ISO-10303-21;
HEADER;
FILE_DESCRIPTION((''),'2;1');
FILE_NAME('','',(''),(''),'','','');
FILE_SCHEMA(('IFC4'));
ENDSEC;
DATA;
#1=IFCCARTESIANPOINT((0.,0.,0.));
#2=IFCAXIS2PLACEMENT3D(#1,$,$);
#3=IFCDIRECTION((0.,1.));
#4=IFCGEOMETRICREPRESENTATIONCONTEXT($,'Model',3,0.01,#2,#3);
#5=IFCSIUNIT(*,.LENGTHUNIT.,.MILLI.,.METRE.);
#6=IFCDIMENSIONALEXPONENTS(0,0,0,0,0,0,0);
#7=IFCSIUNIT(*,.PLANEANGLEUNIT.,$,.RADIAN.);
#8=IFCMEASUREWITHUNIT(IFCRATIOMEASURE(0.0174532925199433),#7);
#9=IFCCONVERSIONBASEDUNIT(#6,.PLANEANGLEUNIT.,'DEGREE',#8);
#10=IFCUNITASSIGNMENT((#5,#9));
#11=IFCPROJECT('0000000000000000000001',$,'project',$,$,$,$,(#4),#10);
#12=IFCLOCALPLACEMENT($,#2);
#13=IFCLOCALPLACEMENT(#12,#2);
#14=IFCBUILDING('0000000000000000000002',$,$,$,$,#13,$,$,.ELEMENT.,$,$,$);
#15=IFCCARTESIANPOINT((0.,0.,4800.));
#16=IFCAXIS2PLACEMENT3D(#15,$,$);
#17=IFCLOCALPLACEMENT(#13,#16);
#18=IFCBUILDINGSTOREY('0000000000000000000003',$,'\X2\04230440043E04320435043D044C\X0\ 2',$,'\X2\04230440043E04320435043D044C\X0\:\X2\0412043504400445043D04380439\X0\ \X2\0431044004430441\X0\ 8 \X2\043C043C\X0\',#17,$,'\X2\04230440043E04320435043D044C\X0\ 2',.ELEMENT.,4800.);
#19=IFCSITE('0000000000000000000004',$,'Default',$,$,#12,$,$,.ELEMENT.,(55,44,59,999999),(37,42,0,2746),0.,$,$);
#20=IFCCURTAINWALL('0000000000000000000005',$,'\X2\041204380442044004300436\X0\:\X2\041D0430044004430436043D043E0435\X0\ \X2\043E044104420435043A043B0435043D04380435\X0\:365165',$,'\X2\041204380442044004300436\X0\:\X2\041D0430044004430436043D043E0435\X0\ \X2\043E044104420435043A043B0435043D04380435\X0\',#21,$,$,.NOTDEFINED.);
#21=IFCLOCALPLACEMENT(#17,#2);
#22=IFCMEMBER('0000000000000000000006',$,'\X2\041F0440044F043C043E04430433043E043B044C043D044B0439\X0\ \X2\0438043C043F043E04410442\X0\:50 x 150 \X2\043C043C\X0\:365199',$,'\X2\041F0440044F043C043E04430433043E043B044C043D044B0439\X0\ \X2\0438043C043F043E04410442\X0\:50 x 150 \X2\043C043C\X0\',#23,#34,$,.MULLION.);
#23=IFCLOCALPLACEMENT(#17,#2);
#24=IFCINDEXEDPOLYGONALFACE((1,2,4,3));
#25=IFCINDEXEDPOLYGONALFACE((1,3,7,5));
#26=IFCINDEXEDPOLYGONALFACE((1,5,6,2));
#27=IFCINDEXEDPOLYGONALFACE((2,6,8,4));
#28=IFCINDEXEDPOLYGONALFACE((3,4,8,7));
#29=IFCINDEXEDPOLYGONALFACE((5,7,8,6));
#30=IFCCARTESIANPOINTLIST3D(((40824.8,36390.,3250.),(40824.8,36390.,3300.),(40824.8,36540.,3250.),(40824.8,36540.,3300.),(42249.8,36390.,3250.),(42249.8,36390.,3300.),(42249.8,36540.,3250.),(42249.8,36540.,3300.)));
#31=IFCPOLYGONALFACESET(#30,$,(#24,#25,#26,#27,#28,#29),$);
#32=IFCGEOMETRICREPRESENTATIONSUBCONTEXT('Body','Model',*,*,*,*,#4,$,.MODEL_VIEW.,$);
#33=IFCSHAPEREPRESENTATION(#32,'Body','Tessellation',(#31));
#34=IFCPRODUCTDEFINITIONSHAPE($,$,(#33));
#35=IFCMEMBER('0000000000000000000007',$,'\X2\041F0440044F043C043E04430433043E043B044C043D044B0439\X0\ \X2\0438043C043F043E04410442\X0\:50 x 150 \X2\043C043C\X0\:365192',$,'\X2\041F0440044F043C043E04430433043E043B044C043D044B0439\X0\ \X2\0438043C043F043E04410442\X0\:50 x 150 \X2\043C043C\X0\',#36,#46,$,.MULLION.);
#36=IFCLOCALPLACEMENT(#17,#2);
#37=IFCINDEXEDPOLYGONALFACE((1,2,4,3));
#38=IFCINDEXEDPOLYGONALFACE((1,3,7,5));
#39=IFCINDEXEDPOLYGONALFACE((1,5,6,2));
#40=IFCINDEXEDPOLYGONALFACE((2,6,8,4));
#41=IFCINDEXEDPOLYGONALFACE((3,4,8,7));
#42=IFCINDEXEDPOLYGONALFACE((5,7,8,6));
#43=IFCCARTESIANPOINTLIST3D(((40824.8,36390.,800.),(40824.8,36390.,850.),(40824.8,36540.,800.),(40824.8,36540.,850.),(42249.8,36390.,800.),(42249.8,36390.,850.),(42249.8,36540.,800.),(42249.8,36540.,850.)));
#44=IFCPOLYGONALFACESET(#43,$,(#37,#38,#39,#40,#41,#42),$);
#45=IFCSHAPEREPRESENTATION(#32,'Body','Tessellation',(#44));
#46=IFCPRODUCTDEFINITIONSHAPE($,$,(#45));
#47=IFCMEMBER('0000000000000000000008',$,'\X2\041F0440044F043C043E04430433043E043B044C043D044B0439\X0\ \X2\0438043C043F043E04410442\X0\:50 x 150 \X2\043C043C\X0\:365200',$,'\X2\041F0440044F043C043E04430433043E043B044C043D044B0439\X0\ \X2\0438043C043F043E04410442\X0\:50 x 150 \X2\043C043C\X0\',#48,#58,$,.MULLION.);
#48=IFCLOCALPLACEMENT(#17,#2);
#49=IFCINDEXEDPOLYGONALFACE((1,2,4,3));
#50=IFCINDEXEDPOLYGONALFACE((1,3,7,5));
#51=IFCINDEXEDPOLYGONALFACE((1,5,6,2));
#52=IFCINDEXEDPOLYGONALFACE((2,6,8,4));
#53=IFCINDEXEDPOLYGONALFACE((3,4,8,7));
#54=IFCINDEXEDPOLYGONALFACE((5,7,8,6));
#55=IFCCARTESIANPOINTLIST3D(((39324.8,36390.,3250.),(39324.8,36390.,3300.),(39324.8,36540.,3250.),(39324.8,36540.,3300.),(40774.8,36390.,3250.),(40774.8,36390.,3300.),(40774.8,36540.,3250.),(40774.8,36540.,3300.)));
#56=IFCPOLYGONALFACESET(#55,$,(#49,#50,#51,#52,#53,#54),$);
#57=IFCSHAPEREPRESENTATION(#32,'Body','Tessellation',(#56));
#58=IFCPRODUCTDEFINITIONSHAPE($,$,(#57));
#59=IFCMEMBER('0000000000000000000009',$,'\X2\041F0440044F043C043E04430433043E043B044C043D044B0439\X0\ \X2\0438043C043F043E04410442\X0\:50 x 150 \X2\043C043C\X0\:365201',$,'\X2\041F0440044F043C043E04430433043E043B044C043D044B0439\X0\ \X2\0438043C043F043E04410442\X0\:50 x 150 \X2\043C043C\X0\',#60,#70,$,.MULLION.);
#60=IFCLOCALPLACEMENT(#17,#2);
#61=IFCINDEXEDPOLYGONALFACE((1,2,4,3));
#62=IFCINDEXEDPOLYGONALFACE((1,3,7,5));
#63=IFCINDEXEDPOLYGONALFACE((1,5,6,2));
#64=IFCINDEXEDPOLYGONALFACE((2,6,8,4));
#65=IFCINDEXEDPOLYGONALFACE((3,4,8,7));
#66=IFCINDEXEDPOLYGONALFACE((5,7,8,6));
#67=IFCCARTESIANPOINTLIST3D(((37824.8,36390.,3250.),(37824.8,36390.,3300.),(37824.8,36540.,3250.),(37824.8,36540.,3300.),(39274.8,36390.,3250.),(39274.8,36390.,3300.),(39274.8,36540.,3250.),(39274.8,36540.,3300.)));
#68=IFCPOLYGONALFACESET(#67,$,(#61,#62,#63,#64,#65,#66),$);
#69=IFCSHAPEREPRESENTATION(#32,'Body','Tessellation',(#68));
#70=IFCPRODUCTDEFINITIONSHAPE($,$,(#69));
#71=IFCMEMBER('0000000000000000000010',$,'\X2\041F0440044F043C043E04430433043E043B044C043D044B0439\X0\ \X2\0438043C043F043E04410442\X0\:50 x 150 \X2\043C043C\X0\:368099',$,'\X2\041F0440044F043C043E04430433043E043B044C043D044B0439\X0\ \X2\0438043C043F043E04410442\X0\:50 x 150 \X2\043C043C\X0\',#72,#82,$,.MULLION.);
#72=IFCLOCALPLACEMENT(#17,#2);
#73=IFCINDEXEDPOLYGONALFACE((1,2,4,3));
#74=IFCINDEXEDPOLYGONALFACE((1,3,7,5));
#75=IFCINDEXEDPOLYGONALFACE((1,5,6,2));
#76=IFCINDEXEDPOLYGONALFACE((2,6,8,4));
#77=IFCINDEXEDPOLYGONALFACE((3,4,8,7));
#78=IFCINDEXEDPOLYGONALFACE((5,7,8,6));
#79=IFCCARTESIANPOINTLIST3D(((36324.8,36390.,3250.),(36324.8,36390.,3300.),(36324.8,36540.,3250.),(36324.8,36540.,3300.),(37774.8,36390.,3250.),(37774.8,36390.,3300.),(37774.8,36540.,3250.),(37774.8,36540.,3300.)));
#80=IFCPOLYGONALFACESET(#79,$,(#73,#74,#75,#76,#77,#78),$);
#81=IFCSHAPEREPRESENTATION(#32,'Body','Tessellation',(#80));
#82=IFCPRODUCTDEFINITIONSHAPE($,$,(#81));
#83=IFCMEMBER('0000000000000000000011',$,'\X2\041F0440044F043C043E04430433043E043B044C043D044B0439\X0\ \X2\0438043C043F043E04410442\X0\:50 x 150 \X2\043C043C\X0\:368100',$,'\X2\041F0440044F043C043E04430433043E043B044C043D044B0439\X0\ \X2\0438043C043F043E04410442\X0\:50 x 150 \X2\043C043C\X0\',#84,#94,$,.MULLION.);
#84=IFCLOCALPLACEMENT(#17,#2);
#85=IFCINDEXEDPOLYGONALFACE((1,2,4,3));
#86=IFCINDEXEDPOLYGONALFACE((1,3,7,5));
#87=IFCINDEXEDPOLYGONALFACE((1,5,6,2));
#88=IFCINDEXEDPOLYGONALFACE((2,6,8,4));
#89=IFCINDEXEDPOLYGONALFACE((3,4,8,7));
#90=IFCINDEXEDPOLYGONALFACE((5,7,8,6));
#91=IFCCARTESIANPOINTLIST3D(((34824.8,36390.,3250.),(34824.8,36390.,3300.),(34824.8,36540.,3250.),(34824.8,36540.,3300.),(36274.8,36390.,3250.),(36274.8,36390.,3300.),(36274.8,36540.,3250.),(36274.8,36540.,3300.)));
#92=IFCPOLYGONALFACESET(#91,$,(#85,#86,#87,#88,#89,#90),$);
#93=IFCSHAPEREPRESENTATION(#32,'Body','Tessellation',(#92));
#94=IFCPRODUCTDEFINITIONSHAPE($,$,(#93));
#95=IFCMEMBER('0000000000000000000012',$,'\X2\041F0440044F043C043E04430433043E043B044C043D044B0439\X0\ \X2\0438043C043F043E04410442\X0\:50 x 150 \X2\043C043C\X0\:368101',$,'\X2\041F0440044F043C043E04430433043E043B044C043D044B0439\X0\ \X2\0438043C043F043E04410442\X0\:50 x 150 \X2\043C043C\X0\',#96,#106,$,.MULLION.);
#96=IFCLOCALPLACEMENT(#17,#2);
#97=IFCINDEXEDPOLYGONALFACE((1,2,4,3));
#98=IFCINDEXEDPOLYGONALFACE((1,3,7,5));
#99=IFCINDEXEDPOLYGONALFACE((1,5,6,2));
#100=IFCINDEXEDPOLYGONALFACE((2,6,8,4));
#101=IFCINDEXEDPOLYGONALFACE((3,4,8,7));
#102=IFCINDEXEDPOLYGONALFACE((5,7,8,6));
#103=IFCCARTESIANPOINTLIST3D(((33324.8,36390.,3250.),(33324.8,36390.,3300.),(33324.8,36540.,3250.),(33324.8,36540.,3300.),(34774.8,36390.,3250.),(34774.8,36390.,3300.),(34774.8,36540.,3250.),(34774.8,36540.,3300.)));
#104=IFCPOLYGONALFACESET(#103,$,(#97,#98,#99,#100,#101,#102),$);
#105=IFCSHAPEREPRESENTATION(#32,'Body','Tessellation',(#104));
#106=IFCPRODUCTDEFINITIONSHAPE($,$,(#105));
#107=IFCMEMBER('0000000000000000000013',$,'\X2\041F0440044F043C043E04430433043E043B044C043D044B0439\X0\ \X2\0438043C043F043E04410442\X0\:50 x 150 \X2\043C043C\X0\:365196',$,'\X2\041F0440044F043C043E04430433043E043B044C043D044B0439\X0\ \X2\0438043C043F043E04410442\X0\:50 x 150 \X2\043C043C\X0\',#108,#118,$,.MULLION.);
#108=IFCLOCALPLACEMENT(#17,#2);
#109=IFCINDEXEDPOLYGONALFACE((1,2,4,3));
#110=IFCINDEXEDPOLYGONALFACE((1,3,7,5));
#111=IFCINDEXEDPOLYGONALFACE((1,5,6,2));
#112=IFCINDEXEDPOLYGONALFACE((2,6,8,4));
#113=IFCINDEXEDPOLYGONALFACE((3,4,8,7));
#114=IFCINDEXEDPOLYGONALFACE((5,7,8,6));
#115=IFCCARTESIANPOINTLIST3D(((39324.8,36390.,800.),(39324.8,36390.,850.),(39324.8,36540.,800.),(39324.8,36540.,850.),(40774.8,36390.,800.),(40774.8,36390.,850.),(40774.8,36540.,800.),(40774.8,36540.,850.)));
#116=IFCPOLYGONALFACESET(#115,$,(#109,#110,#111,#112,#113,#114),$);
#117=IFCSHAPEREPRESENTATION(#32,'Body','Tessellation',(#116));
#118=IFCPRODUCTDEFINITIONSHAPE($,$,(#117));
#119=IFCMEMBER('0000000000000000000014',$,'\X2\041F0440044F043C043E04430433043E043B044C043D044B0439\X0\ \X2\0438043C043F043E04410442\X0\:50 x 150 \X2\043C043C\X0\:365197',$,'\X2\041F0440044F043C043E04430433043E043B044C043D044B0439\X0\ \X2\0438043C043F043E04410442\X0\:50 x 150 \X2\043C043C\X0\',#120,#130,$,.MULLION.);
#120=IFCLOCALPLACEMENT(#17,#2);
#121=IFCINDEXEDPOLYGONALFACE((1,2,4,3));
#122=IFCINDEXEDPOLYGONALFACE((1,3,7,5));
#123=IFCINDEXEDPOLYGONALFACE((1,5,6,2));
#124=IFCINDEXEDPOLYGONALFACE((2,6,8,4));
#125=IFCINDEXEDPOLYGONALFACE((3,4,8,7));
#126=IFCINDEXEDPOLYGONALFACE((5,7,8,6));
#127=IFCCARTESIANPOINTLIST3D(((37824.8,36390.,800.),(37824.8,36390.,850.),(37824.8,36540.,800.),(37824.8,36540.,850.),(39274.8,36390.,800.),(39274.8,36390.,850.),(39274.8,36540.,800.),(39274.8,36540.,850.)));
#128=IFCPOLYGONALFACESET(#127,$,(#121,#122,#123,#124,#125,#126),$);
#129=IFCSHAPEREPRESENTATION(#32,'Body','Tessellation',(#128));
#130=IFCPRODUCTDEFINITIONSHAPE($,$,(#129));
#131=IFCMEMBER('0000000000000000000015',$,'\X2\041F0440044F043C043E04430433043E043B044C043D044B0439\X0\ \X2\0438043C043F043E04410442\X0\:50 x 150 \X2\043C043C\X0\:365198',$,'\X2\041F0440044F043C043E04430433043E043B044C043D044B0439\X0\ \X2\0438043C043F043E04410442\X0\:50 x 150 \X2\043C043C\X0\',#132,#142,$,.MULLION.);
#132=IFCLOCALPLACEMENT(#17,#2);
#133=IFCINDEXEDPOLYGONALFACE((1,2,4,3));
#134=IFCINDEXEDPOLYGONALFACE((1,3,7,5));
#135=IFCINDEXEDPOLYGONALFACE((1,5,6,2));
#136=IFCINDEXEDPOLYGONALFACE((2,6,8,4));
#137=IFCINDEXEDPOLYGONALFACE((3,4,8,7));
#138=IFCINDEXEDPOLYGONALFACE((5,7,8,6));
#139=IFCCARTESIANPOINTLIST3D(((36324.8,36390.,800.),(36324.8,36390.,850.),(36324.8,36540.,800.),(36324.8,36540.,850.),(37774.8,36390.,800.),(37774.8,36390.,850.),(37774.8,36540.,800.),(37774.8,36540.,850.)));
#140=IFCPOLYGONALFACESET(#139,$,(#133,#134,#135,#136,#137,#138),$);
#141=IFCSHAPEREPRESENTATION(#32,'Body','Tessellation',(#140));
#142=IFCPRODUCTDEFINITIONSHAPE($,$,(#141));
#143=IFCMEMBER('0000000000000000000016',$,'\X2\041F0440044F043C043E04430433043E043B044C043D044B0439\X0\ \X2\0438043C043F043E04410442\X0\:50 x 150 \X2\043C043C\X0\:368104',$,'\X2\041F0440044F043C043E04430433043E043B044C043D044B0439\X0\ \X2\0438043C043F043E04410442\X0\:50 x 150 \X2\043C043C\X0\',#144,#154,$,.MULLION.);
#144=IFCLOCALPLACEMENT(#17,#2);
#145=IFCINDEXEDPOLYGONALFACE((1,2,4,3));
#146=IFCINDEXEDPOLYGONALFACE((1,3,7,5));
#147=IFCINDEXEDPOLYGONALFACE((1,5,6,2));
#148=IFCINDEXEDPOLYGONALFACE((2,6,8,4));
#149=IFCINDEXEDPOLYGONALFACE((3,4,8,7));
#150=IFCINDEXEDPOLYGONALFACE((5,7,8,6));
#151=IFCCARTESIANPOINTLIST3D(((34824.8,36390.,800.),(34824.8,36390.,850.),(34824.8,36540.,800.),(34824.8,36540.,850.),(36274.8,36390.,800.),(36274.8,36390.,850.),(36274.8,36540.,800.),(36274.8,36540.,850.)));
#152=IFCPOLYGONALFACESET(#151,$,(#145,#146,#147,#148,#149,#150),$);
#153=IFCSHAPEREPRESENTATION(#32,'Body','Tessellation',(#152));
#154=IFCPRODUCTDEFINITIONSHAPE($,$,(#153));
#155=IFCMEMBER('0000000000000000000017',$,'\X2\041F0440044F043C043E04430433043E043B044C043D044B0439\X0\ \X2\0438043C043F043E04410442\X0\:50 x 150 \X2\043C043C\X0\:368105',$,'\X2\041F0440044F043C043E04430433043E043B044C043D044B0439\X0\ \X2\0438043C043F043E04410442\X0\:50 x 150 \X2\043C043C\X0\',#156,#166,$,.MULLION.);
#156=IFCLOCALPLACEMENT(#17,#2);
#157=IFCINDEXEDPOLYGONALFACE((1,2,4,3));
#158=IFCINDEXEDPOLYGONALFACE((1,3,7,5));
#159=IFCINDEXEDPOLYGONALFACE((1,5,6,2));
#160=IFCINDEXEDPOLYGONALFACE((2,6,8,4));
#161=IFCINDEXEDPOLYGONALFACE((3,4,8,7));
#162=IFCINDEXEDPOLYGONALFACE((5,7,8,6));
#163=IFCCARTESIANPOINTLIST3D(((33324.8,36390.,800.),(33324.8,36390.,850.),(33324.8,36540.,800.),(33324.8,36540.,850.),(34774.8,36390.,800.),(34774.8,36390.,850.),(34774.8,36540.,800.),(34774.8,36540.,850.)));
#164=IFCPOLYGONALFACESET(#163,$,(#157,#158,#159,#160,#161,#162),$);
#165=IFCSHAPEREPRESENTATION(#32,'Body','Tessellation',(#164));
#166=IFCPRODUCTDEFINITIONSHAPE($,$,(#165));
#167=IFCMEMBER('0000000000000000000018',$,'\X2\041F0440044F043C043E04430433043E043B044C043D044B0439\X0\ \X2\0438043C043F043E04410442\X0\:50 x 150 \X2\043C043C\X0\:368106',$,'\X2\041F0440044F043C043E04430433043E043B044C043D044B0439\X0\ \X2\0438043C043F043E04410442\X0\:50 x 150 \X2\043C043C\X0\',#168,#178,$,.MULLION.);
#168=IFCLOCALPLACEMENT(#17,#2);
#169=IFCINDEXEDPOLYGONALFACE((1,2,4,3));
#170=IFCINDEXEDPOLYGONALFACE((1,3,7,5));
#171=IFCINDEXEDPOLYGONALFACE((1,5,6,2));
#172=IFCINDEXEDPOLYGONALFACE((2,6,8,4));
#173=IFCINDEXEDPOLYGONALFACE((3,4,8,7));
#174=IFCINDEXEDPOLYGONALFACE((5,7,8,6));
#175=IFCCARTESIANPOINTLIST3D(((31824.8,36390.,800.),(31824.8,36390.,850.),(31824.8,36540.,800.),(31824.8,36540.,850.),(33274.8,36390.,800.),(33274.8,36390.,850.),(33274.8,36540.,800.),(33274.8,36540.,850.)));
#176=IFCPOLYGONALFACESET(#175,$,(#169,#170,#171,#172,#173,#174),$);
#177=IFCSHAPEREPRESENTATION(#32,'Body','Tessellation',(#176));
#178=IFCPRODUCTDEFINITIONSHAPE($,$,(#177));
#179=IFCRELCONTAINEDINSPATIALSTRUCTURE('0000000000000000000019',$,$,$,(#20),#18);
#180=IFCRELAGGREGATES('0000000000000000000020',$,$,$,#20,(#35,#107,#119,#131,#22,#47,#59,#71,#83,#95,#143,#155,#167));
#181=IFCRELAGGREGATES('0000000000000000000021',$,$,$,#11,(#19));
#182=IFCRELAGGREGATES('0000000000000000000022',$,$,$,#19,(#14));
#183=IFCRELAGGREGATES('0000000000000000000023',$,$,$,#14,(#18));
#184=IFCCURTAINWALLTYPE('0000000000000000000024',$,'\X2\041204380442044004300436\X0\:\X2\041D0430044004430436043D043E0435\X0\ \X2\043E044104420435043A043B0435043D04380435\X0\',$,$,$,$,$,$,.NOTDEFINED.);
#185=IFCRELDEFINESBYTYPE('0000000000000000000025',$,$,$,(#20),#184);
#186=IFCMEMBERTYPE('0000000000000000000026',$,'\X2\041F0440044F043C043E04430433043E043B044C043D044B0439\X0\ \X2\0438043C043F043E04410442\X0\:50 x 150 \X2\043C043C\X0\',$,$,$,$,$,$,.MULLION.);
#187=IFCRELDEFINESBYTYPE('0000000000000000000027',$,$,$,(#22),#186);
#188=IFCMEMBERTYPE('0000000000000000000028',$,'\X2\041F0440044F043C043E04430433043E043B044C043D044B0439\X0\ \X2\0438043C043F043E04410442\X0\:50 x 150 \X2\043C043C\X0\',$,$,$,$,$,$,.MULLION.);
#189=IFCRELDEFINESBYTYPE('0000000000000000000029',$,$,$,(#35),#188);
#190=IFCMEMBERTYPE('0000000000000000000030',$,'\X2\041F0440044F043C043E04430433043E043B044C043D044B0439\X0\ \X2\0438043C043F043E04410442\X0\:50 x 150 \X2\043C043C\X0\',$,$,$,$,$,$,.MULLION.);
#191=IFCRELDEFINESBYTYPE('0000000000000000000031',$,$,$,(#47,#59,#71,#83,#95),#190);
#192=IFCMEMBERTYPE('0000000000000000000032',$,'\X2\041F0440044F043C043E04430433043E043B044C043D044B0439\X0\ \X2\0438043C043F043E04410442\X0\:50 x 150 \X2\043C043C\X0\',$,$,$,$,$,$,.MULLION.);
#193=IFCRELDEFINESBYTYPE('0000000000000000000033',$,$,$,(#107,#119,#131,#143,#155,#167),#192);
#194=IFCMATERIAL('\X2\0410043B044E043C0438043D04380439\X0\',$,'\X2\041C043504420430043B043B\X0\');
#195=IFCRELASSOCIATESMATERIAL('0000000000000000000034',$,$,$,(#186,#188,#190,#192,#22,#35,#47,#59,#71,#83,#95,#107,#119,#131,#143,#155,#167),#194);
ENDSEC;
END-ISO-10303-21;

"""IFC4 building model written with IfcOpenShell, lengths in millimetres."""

from ifc_helpers import new_model, entity, si_unit, converted_unit, direction, frame, origin, origin_2d_with_axis, place, context, subcontext, project, spatial, rectangle, extrude, source, transform, mapped, material, material_profile, profile_set, profile_usage, type_object, type_shapes, element, aggregate, save


model = new_model("IFC4")

# Units and contexts
model_context = context("Model", 3, precision=0.01, world=origin(), true_north=direction((0.0, 1.0)))
body_context = subcontext(model_context, "Body", "Model", "MODEL_VIEW")
ifc_project = project(units=[si_unit("LENGTHUNIT", "METRE", prefix="MILLI"), converted_unit("PLANEANGLEUNIT", "DEGREE", entity("IfcRatioMeasure", 0.0174532925199433), si_unit("PLANEANGLEUNIT", "RADIAN"), dimensions=[0, 0, 0, 0, 0, 0, 0])], contexts=[model_context])

# Site, building, storey
site_placement = place(None, origin())
site = spatial("IfcSite", under=ifc_project, at=site_placement, Name="Default", CompositionType="ELEMENT", RefLatitude=(55, 44, 59, 999999), RefLongitude=(37, 42, 0, 2746), RefElevation=0.0)
building_placement = place(site_placement, origin())
building = spatial("IfcBuilding", under=site, at=building_placement, CompositionType="ELEMENT")
storey_placement = place(building_placement, frame((0.0, 0.0, 4800.0)))
storey = spatial("IfcBuildingStorey", under=building, at=storey_placement, Name="Уровень 2", ObjectType="Уровень:Верхний брус 8 мм", LongName="Уровень 2", CompositionType="ELEMENT", Elevation=4800.0)

# Curtain wall, members
curtain_wall_type = type_object("IfcCurtainWallType", Name="Витраж:Наружное остекление", PredefinedType="NOTDEFINED")
curtain_wall_placement = place(storey_placement, frame((0.0, 0.0, -4800.0)))
curtain_wall = element("IfcCurtainWall", 1, at=curtain_wall_placement, inside=storey, type_object=curtain_wall_type, Name="Витраж:Наружное остекление:365165", ObjectType="Витраж:Наружное остекление", PredefinedType="NOTDEFINED")
ifc_material_1 = material(Name="Алюминий", Category="Металл")
ifc_material_profile = material_profile(ifc_material_1, rectangle(XDim=150.0, YDim=50.0, at=origin_2d_with_axis()), Name="50 x 150 мм")
ifc_profile_set = profile_set([ifc_material_profile], Name="50 x 150 мм")
ifc_profile_usage_1 = profile_usage(ifc_profile_set)
member_type_1 = type_object("IfcMemberType", Name="Прямоугольный импост:50 x 150 мм", PredefinedType="MULLION", material=ifc_profile_set)
shared_shape_1 = source(origin(), body_context, "Body", "SweptSolid", [
    extrude(rectangle(XDim=150.0, YDim=50.0, at=origin_2d_with_axis()), frame((-25.0, 0.0, -1425.0), z_axis=(0.0, 0.0, 1.0), x_axis=(0.0, -1.0, 0.0)), (0.0, 0.0, 1.0), 1425.0),
])
type_shapes(member_type_1, [shared_shape_1])
member_1_placement = place(storey_placement, frame((40824.8, 36465.0, 3300.0), z_axis=(-1.0, 0.0, 0.0), x_axis=(0.0, 0.0, 1.0)))
member_1 = element("IfcMember", 2, at=member_1_placement, type_object=member_type_1, material=ifc_profile_usage_1, Name="Прямоугольный импост:50 x 150 мм:365199", ObjectType="Прямоугольный импост:50 x 150 мм", PredefinedType="MULLION", context=body_context, shape_type="MappedRepresentation", body=[
    mapped(shared_shape_1, transform((0.0, 0.0, 0.0), scale=1.0)),
])
ifc_profile_usage_2 = profile_usage(ifc_profile_set)
member_type_2 = type_object("IfcMemberType", Name="Прямоугольный импост:50 x 150 мм", PredefinedType="MULLION", material=ifc_profile_set)
shared_shape_2 = source(origin(), body_context, "Body", "SweptSolid", [
    extrude(rectangle(XDim=150.0, YDim=50.0, at=origin_2d_with_axis()), frame((-25.0, 0.0, -1425.0), z_axis=(0.0, 0.0, 1.0), x_axis=(0.0, -1.0, 0.0)), (0.0, 0.0, 1.0), 1425.0),
])
type_shapes(member_type_2, [shared_shape_2])
member_2_placement = place(storey_placement, frame((42249.8, 36465.0, 800.0), z_axis=(1.0, 0.0, 0.0), x_axis=(0.0, 0.0, -1.0)))
member_2 = element("IfcMember", 3, at=member_2_placement, type_object=member_type_2, material=ifc_profile_usage_2, Name="Прямоугольный импост:50 x 150 мм:365192", ObjectType="Прямоугольный импост:50 x 150 мм", PredefinedType="MULLION", context=body_context, shape_type="MappedRepresentation", body=[
    mapped(shared_shape_2, transform((0.0, 0.0, 0.0), scale=1.0)),
])
ifc_profile_usage_3 = profile_usage(ifc_profile_set)
member_type_3 = type_object("IfcMemberType", Name="Прямоугольный импост:50 x 150 мм", PredefinedType="MULLION", material=ifc_profile_set)
shared_shape_3 = source(origin(), body_context, "Body", "SweptSolid", [
    extrude(rectangle(XDim=150.0, YDim=50.0, at=origin_2d_with_axis()), frame((-25.0, 0.0, -1450.0), z_axis=(0.0, 0.0, 1.0), x_axis=(0.0, -1.0, 0.0)), (0.0, 0.0, 1.0), 1450.0),
])
type_shapes(member_type_3, [shared_shape_3])
member_3_placement = place(storey_placement, frame((39324.8, 36465.0, 3300.0), z_axis=(-1.0, 0.0, 0.0), x_axis=(0.0, 0.0, 1.0)))
member_3 = element("IfcMember", 4, at=member_3_placement, type_object=member_type_3, material=ifc_profile_usage_3, Name="Прямоугольный импост:50 x 150 мм:365200", ObjectType="Прямоугольный импост:50 x 150 мм", PredefinedType="MULLION", context=body_context, shape_type="MappedRepresentation", body=[
    mapped(shared_shape_3, transform((0.0, 0.0, 0.0), scale=1.0)),
])
ifc_profile_usage_4 = profile_usage(ifc_profile_set)
member_4_placement = place(storey_placement, frame((37824.8, 36465.0, 3300.0), z_axis=(-1.0, 0.0, 0.0), x_axis=(0.0, 0.0, 1.0)))
member_4 = element("IfcMember", 5, at=member_4_placement, type_object=member_type_3, material=ifc_profile_usage_4, Name="Прямоугольный импост:50 x 150 мм:365201", ObjectType="Прямоугольный импост:50 x 150 мм", PredefinedType="MULLION", context=body_context, shape_type="MappedRepresentation", body=[
    mapped(shared_shape_3, transform((0.0, 0.0, 0.0), scale=1.0)),
])
ifc_profile_usage_5 = profile_usage(ifc_profile_set)
member_5_placement = place(storey_placement, frame((36324.8, 36465.0, 3300.0), z_axis=(-1.0, 0.0, 0.0), x_axis=(0.0, 0.0, 1.0)))
member_5 = element("IfcMember", 6, at=member_5_placement, type_object=member_type_3, material=ifc_profile_usage_5, Name="Прямоугольный импост:50 x 150 мм:368099", ObjectType="Прямоугольный импост:50 x 150 мм", PredefinedType="MULLION", context=body_context, shape_type="MappedRepresentation", body=[
    mapped(shared_shape_3, transform((0.0, 0.0, 0.0), scale=1.0)),
])
ifc_profile_usage_6 = profile_usage(ifc_profile_set)
member_6_placement = place(storey_placement, frame((34824.8, 36465.0, 3300.0), z_axis=(-1.0, 0.0, 0.0), x_axis=(0.0, 0.0, 1.0)))
member_6 = element("IfcMember", 7, at=member_6_placement, type_object=member_type_3, material=ifc_profile_usage_6, Name="Прямоугольный импост:50 x 150 мм:368100", ObjectType="Прямоугольный импост:50 x 150 мм", PredefinedType="MULLION", context=body_context, shape_type="MappedRepresentation", body=[
    mapped(shared_shape_3, transform((0.0, 0.0, 0.0), scale=1.0)),
])
ifc_profile_usage_7 = profile_usage(ifc_profile_set)
member_7_placement = place(storey_placement, frame((33324.8, 36465.0, 3300.0), z_axis=(-1.0, 0.0, 0.0), x_axis=(0.0, 0.0, 1.0)))
member_7 = element("IfcMember", 8, at=member_7_placement, type_object=member_type_3, material=ifc_profile_usage_7, Name="Прямоугольный импост:50 x 150 мм:368101", ObjectType="Прямоугольный импост:50 x 150 мм", PredefinedType="MULLION", context=body_context, shape_type="MappedRepresentation", body=[
    mapped(shared_shape_3, transform((0.0, 0.0, 0.0), scale=1.0)),
])
ifc_profile_usage_8 = profile_usage(ifc_profile_set)
member_type_4 = type_object("IfcMemberType", Name="Прямоугольный импост:50 x 150 мм", PredefinedType="MULLION", material=ifc_profile_set)
shared_shape_4 = source(origin(), body_context, "Body", "SweptSolid", [
    extrude(rectangle(XDim=150.0, YDim=50.0, at=origin_2d_with_axis()), frame((-25.0, 0.0, -1450.0), z_axis=(0.0, 0.0, 1.0), x_axis=(0.0, -1.0, 0.0)), (0.0, 0.0, 1.0), 1450.0),
])
type_shapes(member_type_4, [shared_shape_4])
member_8_placement = place(storey_placement, frame((40774.8, 36465.0, 800.0), z_axis=(1.0, 0.0, 0.0), x_axis=(0.0, 0.0, -1.0)))
member_8 = element("IfcMember", 9, at=member_8_placement, type_object=member_type_4, material=ifc_profile_usage_8, Name="Прямоугольный импост:50 x 150 мм:365196", ObjectType="Прямоугольный импост:50 x 150 мм", PredefinedType="MULLION", context=body_context, shape_type="MappedRepresentation", body=[
    mapped(shared_shape_4, transform((0.0, 0.0, 0.0), scale=1.0)),
])
ifc_profile_usage_9 = profile_usage(ifc_profile_set)
member_9_placement = place(storey_placement, frame((39274.8, 36465.0, 800.0), z_axis=(1.0, 0.0, 0.0), x_axis=(0.0, 0.0, -1.0)))
member_9 = element("IfcMember", 10, at=member_9_placement, type_object=member_type_4, material=ifc_profile_usage_9, Name="Прямоугольный импост:50 x 150 мм:365197", ObjectType="Прямоугольный импост:50 x 150 мм", PredefinedType="MULLION", context=body_context, shape_type="MappedRepresentation", body=[
    mapped(shared_shape_4, transform((0.0, 0.0, 0.0), scale=1.0)),
])
ifc_profile_usage_10 = profile_usage(ifc_profile_set)
member_10_placement = place(storey_placement, frame((37774.8, 36465.0, 800.0), z_axis=(1.0, 0.0, 0.0), x_axis=(0.0, 0.0, -1.0)))
member_10 = element("IfcMember", 11, at=member_10_placement, type_object=member_type_4, material=ifc_profile_usage_10, Name="Прямоугольный импост:50 x 150 мм:365198", ObjectType="Прямоугольный импост:50 x 150 мм", PredefinedType="MULLION", context=body_context, shape_type="MappedRepresentation", body=[
    mapped(shared_shape_4, transform((0.0, 0.0, 0.0), scale=1.0)),
])
ifc_profile_usage_11 = profile_usage(ifc_profile_set)
member_11_placement = place(storey_placement, frame((36274.8, 36465.0, 800.0), z_axis=(1.0, 0.0, 0.0), x_axis=(0.0, 0.0, -1.0)))
member_11 = element("IfcMember", 12, at=member_11_placement, type_object=member_type_4, material=ifc_profile_usage_11, Name="Прямоугольный импост:50 x 150 мм:368104", ObjectType="Прямоугольный импост:50 x 150 мм", PredefinedType="MULLION", context=body_context, shape_type="MappedRepresentation", body=[
    mapped(shared_shape_4, transform((0.0, 0.0, 0.0), scale=1.0)),
])
ifc_profile_usage_12 = profile_usage(ifc_profile_set)
member_12_placement = place(storey_placement, frame((34774.8, 36465.0, 800.0), z_axis=(1.0, 0.0, 0.0), x_axis=(0.0, 0.0, -1.0)))
member_12 = element("IfcMember", 13, at=member_12_placement, type_object=member_type_4, material=ifc_profile_usage_12, Name="Прямоугольный импост:50 x 150 мм:368105", ObjectType="Прямоугольный импост:50 x 150 мм", PredefinedType="MULLION", context=body_context, shape_type="MappedRepresentation", body=[
    mapped(shared_shape_4, transform((0.0, 0.0, 0.0), scale=1.0)),
])
ifc_profile_usage_13 = profile_usage(ifc_profile_set)
member_13_placement = place(storey_placement, frame((33274.8, 36465.0, 800.0), z_axis=(1.0, 0.0, 0.0), x_axis=(0.0, 0.0, -1.0)))
member_13 = element("IfcMember", 14, at=member_13_placement, type_object=member_type_4, material=ifc_profile_usage_13, Name="Прямоугольный импост:50 x 150 мм:368106", ObjectType="Прямоугольный импост:50 x 150 мм", PredefinedType="MULLION", context=body_context, shape_type="MappedRepresentation", body=[
    mapped(shared_shape_4, transform((0.0, 0.0, 0.0), scale=1.0)),
])
aggregate(curtain_wall, [member_2, member_8, member_9, member_10, member_1, member_3, member_4, member_5, member_6, member_7, member_11, member_12, member_13])

save(model, "model.ifc")
